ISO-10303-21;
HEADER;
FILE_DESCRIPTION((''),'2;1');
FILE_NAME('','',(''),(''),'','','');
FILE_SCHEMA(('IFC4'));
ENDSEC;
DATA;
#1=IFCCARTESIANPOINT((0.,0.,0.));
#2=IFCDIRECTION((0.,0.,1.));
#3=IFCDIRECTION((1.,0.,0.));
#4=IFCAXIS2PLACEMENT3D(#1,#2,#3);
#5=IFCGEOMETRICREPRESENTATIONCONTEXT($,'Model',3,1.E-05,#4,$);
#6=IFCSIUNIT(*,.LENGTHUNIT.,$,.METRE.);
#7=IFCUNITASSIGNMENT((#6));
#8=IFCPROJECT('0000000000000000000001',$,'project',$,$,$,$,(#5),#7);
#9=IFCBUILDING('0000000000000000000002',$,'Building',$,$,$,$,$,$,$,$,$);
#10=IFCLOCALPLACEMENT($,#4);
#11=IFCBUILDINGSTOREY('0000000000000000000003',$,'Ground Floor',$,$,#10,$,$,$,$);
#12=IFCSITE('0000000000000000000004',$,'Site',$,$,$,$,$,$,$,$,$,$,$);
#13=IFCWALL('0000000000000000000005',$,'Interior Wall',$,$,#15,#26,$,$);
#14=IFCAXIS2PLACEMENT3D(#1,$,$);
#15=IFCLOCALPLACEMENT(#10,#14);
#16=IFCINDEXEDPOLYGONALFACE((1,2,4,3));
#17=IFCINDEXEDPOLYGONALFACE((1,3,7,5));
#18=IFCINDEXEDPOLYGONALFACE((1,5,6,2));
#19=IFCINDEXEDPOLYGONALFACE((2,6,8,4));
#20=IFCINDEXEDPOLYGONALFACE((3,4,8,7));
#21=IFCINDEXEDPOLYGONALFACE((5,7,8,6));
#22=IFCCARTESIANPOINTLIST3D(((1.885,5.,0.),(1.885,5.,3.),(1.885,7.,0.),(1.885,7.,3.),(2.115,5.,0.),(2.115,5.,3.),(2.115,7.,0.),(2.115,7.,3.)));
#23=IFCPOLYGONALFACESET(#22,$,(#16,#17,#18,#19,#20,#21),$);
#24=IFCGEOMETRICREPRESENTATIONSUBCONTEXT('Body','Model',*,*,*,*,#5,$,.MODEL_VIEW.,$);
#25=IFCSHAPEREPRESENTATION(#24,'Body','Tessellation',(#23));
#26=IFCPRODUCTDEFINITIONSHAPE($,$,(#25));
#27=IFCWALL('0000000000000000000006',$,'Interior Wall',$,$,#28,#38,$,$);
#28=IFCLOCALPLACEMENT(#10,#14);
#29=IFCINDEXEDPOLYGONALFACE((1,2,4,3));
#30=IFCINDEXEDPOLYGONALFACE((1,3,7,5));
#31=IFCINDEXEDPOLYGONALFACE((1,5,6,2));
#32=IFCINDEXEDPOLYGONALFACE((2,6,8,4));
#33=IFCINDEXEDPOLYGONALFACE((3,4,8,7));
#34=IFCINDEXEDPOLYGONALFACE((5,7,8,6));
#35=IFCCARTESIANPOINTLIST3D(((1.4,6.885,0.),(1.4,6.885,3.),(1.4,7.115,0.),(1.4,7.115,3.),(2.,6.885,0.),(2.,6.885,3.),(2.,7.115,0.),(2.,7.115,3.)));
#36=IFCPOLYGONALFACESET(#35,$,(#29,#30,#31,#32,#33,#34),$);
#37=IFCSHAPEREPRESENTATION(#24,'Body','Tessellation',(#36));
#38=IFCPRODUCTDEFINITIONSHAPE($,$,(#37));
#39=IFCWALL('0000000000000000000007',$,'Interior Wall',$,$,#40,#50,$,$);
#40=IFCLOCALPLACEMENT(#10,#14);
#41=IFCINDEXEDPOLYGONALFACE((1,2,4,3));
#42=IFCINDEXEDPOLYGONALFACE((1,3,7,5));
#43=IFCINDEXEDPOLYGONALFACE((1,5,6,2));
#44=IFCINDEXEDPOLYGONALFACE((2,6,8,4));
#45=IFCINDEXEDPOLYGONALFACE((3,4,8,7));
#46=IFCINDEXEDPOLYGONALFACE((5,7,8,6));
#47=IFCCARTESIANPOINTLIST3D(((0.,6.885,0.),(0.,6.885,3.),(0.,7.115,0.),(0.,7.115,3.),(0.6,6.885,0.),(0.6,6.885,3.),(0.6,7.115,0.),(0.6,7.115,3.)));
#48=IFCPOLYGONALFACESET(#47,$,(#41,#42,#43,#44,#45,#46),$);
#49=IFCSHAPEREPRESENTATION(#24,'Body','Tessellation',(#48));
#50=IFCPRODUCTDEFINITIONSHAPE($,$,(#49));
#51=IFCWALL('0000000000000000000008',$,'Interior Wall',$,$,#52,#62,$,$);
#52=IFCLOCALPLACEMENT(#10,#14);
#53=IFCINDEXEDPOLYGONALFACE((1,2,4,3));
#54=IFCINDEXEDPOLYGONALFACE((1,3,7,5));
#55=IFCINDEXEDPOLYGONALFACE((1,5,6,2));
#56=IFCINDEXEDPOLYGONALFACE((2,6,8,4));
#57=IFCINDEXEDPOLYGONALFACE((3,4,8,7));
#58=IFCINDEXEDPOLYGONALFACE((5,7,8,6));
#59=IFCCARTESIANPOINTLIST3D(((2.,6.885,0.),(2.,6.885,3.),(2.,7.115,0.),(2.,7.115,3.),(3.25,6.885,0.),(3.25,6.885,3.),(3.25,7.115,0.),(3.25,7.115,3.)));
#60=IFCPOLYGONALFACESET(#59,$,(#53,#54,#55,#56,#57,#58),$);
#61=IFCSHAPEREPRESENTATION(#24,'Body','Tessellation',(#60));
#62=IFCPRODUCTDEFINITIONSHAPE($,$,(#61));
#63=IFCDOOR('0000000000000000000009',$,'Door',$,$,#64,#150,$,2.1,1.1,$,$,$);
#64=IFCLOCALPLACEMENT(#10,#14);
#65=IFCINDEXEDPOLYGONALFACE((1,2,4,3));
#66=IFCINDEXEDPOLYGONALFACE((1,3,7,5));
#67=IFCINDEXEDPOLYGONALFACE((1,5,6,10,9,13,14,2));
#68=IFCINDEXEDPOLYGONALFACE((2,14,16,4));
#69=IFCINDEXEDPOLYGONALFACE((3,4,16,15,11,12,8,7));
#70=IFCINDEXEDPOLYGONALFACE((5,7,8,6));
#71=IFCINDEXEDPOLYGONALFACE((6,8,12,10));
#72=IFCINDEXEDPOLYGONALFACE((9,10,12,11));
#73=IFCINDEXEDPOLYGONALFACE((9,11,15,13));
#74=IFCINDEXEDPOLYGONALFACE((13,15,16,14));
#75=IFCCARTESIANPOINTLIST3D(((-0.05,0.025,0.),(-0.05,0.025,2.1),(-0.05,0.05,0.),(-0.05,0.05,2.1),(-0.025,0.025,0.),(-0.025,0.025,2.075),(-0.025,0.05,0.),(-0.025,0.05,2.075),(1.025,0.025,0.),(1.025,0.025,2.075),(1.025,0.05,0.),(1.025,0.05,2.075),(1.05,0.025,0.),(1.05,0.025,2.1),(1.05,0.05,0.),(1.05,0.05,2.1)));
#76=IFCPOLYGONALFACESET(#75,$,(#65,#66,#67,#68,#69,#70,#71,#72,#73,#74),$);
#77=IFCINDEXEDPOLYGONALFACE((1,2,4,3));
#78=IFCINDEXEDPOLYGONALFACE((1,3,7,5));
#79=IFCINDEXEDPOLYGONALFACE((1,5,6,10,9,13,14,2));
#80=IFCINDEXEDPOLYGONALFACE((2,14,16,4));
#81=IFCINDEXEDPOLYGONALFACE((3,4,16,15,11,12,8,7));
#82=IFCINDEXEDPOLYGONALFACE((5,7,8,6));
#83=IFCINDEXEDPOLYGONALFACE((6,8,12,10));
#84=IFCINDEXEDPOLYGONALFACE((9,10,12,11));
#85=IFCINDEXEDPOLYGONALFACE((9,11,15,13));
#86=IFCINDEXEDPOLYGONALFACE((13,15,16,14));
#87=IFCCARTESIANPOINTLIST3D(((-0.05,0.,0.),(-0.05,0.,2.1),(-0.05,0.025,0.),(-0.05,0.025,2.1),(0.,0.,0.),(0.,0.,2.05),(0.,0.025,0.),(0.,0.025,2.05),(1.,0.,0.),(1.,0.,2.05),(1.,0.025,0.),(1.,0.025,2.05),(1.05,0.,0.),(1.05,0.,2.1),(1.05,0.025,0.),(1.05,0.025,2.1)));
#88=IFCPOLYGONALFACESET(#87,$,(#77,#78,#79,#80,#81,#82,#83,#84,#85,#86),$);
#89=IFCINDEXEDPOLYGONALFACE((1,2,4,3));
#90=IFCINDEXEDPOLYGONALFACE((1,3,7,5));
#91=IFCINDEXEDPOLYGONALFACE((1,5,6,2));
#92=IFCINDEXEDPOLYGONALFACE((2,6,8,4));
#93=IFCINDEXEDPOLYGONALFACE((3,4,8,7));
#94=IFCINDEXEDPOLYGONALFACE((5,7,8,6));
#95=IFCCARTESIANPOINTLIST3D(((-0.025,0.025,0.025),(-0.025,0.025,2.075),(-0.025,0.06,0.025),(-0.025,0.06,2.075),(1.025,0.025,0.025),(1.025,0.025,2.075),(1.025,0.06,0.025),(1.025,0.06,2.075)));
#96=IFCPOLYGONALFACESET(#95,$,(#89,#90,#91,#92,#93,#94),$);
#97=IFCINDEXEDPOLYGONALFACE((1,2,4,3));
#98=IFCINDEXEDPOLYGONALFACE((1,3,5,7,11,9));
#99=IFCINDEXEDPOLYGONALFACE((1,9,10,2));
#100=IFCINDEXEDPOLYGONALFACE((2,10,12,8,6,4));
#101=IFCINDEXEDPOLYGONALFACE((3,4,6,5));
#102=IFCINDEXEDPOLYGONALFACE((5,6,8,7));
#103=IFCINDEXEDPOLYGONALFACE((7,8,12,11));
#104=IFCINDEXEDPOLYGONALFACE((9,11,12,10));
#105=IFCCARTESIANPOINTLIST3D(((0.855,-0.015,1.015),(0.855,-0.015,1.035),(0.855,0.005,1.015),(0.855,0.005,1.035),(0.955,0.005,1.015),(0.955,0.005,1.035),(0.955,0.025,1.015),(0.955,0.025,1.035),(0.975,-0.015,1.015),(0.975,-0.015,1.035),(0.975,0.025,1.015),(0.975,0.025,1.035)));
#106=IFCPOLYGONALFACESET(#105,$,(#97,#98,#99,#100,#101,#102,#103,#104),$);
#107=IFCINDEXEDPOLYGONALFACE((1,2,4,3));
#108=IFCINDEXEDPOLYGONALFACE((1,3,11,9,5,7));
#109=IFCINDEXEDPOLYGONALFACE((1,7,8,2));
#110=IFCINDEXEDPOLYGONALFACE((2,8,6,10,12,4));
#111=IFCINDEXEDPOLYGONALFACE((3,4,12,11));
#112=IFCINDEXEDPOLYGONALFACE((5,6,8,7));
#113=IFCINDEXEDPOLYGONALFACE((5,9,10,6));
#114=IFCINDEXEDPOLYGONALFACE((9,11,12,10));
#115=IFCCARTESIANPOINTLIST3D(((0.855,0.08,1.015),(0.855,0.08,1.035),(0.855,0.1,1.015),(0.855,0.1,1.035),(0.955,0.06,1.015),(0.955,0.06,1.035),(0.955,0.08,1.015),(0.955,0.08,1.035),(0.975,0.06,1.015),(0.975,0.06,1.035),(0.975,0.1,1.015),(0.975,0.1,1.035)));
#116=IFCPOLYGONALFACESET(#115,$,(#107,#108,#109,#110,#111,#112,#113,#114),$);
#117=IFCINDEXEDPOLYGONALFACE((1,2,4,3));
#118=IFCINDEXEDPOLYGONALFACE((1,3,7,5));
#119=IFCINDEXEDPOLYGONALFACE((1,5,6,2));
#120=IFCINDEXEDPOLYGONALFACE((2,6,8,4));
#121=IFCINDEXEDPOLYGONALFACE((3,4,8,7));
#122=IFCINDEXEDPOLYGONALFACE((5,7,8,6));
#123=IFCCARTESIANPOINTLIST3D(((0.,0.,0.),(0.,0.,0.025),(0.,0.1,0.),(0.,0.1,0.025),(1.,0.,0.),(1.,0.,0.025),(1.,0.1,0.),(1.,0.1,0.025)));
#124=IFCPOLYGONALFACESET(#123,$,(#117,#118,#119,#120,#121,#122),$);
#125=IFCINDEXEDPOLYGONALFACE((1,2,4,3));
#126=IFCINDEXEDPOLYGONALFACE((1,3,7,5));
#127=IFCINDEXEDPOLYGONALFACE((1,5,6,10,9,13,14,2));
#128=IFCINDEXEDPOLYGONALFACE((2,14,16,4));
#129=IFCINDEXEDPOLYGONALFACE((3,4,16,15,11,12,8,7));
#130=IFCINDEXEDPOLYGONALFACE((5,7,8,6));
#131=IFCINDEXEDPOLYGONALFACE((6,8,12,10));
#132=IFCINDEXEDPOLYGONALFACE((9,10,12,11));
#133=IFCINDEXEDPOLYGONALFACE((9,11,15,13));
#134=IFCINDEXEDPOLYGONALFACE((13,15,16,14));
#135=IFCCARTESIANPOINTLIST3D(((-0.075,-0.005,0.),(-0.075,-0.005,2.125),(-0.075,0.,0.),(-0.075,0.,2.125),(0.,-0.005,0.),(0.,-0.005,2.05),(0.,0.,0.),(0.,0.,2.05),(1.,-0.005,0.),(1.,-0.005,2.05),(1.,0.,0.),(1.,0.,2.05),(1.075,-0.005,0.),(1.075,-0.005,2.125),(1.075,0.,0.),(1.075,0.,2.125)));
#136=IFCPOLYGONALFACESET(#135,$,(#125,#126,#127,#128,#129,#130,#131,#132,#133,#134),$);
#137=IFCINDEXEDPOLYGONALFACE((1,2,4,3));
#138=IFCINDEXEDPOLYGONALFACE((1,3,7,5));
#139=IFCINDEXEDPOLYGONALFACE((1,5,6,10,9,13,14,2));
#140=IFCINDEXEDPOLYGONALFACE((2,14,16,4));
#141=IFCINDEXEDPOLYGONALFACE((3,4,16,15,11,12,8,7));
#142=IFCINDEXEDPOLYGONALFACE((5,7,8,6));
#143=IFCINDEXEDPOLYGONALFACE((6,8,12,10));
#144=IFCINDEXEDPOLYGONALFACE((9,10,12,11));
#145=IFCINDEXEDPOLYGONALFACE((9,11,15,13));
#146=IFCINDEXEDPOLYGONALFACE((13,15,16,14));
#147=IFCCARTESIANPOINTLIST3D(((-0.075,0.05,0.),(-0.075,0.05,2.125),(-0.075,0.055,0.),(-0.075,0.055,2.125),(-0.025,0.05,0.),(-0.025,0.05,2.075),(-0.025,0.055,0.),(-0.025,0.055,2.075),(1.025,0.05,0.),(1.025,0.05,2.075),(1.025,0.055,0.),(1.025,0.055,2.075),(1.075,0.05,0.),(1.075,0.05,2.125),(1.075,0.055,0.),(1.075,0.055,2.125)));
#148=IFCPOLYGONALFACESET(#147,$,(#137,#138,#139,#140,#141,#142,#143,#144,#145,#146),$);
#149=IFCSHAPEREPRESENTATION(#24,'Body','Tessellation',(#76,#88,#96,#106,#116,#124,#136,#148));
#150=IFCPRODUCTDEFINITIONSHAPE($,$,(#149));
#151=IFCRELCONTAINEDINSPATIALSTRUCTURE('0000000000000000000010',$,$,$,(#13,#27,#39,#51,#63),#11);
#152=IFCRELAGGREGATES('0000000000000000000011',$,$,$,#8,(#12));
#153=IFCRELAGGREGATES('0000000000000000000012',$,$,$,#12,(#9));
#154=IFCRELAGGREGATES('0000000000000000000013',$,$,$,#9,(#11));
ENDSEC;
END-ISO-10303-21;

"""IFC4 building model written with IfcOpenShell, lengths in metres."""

from ifc_helpers import new_model, si_unit, frame, origin_with_axes, place, context, subcontext, project, spatial, line, indexed_curve, outline, extrude, element, save


model = new_model("IFC4")

# Units and contexts
model_context = context("Model", 3, precision=1e-05, world=origin_with_axes())
body_context = subcontext(model_context, "Body", "Model", "MODEL_VIEW")
ifc_project = project(units=[si_unit("LENGTHUNIT", "METRE")], contexts=[model_context])

# Site, building, storey
site = spatial("IfcSite", under=ifc_project, Name="Site")
building = spatial("IfcBuilding", under=site, Name="Building")
storey_placement = place(None, origin_with_axes())
storey = spatial("IfcBuildingStorey", under=building, at=storey_placement, Name="Ground Floor")

# Walls
wall_1_placement = place(storey_placement, frame((2.0, 5.0, 0.0), z_axis=(0.0, 0.0, 1.0), x_axis=(0.0, 1.0, 0.0)))
element("IfcWall", 1, at=wall_1_placement, inside=storey, Name="Interior Wall", context=body_context, shape_type="SweptSolid", body=[
    extrude(outline(indexed_curve([(0.0, 0.0), (0.0, 0.23), (2.0, 0.23), (2.0, 0.0), (0.0, 0.0)], self_intersect=False)), frame((0.0, -0.115, 0.0), z_axis=(0.0, 0.0, 1.0), x_axis=(1.0, 0.0, 0.0)), (0.0, 0.0, 1.0), 3.0),
])
for number, where, z_axis, x_axis, name in (
    (2, (2.0, 7.0, 0.0), (0.0, 0.0, 1.0), (-1.0, 0.0, 0.0), "Interior Wall"),
    (3, (0.6, 7.0, 0.0), (0.0, 0.0, 1.0), (-1.0, 0.0, 0.0), "Interior Wall"),
):
    element("IfcWall", number, at=place(storey_placement, frame(where, z_axis=z_axis, x_axis=x_axis)), inside=storey, Name=name, context=body_context, shape_type="SweptSolid", body=[
        extrude(outline(indexed_curve([(0.0, 0.0), (0.0, 0.23), (0.6, 0.23), (0.6, 0.0), (0.0, 0.0)], self_intersect=False)), frame((0.0, -0.115, 0.0), z_axis=(0.0, 0.0, 1.0), x_axis=(1.0, 0.0, 0.0)), (0.0, 0.0, 1.0), 3.0),
    ])
wall_2_placement = place(storey_placement, frame((3.25, 7.0, 0.0), z_axis=(0.0, 0.0, 1.0), x_axis=(-1.0, 0.0, 0.0)))
element("IfcWall", 4, at=wall_2_placement, inside=storey, Name="Interior Wall", context=body_context, shape_type="SweptSolid", body=[
    extrude(outline(indexed_curve([(0.0, 0.0), (0.0, 0.23), (1.25, 0.23), (1.25, 0.0), (0.0, 0.0)], self_intersect=False)), frame((0.0, -0.115, 0.0), z_axis=(0.0, 0.0, 1.0), x_axis=(1.0, 0.0, 0.0)), (0.0, 0.0, 1.0), 3.0),
])

# Door
door_1_placement = place(storey_placement, frame((-0.05, 0.0, 0.0), z_axis=(0.0, 0.0, 1.0), x_axis=(1.0, 0.0, 0.0)))
element("IfcDoor", 5, at=door_1_placement, inside=storey, Name="Door", OverallHeight=2.1, OverallWidth=1.1, context=body_context, shape_type="SweptSolid", body=[
    extrude(outline(indexed_curve([(0.0, 0.0), (0.0, 2.1), (1.1, 2.1), (1.1, 0.0), (1.075, 0.0), (1.075, 2.075), (0.025, 2.075), (0.025, 0.0)], segments=[line(1, 2, 3, 4, 5, 6, 7, 8, 1)])), frame((0.0, 0.025, 0.0), z_axis=(0.0, -1.0, 0.0), x_axis=(1.0, 0.0, 0.0)), (0.0, 0.0, -1.0), 0.025),
    extrude(outline(indexed_curve([(0.0, 0.0), (0.0, 2.1), (1.1, 2.1), (1.1, 0.0), (1.05, 0.0), (1.05, 2.05), (0.05, 2.05), (0.05, 0.0)], segments=[line(1, 2, 3, 4, 5, 6, 7, 8, 1)])), frame((0.0, 0.0, 0.0), z_axis=(0.0, -1.0, 0.0), x_axis=(1.0, 0.0, 0.0)), (0.0, 0.0, -1.0), 0.025),
    extrude(outline(indexed_curve([(0.0, 0.0), (1.05, 0.0), (1.05, 0.035), (0.0, 0.035)], segments=[line(1, 2, 3, 4, 1)])), frame((0.025, 0.025, 0.025), z_axis=(0.0, 0.0, 1.0), x_axis=(1.0, 0.0, 0.0)), (0.0, 0.0, 1.0), 2.05),
    extrude(outline(indexed_curve([(0.0, 0.0), (0.0, -0.04), (-0.12, -0.04), (-0.12, -0.02), (-0.02, -0.02), (-0.02, 0.0)], segments=[line(1, 2, 3, 4, 5, 6, 1)])), frame((1.025, 0.025, 1.015), z_axis=(0.0, 0.0, 1.0), x_axis=(1.0, 0.0, 0.0)), (0.0, 0.0, 1.0), 0.02),
    extrude(outline(indexed_curve([(0.0, 0.0), (0.0, 0.04), (-0.12, 0.04), (-0.12, 0.02), (-0.02, 0.02), (-0.02, 0.0)], segments=[line(1, 2, 3, 4, 5, 6, 1)])), frame((1.025, 0.06, 1.015), z_axis=(0.0, 0.0, 1.0), x_axis=(1.0, 0.0, 0.0)), (0.0, 0.0, 1.0), 0.02),
    extrude(outline(indexed_curve([(0.0, 0.0), (1.0, 0.0), (1.0, 0.1), (0.0, 0.1)], segments=[line(1, 2, 3, 4, 1)])), frame((0.05, 0.0, 0.0), z_axis=(0.0, 0.0, 1.0), x_axis=(1.0, 0.0, 0.0)), (0.0, 0.0, 1.0), 0.025),
    extrude(outline(indexed_curve([(0.0, 0.0), (0.0, 2.125), (1.15, 2.125), (1.15, 0.0), (1.075, 0.0), (1.075, 2.05), (0.075, 2.05), (0.075, 0.0)], segments=[line(1, 2, 3, 4, 5, 6, 7, 8, 1)])), frame((-0.025, -0.005, 0.0), z_axis=(0.0, -1.0, 0.0), x_axis=(1.0, 0.0, 0.0)), (0.0, 0.0, -1.0), 0.005),
    extrude(outline(indexed_curve([(0.0, 0.0), (0.0, 2.125), (1.15, 2.125), (1.15, 0.0), (1.1, 0.0), (1.1, 2.075), (0.05, 2.075), (0.05, 0.0)], segments=[line(1, 2, 3, 4, 5, 6, 7, 8, 1)])), frame((-0.025, 0.05, 0.0), z_axis=(0.0, -1.0, 0.0), x_axis=(1.0, 0.0, 0.0)), (0.0, 0.0, -1.0), 0.005),
])

save(model, "model.ifc")
